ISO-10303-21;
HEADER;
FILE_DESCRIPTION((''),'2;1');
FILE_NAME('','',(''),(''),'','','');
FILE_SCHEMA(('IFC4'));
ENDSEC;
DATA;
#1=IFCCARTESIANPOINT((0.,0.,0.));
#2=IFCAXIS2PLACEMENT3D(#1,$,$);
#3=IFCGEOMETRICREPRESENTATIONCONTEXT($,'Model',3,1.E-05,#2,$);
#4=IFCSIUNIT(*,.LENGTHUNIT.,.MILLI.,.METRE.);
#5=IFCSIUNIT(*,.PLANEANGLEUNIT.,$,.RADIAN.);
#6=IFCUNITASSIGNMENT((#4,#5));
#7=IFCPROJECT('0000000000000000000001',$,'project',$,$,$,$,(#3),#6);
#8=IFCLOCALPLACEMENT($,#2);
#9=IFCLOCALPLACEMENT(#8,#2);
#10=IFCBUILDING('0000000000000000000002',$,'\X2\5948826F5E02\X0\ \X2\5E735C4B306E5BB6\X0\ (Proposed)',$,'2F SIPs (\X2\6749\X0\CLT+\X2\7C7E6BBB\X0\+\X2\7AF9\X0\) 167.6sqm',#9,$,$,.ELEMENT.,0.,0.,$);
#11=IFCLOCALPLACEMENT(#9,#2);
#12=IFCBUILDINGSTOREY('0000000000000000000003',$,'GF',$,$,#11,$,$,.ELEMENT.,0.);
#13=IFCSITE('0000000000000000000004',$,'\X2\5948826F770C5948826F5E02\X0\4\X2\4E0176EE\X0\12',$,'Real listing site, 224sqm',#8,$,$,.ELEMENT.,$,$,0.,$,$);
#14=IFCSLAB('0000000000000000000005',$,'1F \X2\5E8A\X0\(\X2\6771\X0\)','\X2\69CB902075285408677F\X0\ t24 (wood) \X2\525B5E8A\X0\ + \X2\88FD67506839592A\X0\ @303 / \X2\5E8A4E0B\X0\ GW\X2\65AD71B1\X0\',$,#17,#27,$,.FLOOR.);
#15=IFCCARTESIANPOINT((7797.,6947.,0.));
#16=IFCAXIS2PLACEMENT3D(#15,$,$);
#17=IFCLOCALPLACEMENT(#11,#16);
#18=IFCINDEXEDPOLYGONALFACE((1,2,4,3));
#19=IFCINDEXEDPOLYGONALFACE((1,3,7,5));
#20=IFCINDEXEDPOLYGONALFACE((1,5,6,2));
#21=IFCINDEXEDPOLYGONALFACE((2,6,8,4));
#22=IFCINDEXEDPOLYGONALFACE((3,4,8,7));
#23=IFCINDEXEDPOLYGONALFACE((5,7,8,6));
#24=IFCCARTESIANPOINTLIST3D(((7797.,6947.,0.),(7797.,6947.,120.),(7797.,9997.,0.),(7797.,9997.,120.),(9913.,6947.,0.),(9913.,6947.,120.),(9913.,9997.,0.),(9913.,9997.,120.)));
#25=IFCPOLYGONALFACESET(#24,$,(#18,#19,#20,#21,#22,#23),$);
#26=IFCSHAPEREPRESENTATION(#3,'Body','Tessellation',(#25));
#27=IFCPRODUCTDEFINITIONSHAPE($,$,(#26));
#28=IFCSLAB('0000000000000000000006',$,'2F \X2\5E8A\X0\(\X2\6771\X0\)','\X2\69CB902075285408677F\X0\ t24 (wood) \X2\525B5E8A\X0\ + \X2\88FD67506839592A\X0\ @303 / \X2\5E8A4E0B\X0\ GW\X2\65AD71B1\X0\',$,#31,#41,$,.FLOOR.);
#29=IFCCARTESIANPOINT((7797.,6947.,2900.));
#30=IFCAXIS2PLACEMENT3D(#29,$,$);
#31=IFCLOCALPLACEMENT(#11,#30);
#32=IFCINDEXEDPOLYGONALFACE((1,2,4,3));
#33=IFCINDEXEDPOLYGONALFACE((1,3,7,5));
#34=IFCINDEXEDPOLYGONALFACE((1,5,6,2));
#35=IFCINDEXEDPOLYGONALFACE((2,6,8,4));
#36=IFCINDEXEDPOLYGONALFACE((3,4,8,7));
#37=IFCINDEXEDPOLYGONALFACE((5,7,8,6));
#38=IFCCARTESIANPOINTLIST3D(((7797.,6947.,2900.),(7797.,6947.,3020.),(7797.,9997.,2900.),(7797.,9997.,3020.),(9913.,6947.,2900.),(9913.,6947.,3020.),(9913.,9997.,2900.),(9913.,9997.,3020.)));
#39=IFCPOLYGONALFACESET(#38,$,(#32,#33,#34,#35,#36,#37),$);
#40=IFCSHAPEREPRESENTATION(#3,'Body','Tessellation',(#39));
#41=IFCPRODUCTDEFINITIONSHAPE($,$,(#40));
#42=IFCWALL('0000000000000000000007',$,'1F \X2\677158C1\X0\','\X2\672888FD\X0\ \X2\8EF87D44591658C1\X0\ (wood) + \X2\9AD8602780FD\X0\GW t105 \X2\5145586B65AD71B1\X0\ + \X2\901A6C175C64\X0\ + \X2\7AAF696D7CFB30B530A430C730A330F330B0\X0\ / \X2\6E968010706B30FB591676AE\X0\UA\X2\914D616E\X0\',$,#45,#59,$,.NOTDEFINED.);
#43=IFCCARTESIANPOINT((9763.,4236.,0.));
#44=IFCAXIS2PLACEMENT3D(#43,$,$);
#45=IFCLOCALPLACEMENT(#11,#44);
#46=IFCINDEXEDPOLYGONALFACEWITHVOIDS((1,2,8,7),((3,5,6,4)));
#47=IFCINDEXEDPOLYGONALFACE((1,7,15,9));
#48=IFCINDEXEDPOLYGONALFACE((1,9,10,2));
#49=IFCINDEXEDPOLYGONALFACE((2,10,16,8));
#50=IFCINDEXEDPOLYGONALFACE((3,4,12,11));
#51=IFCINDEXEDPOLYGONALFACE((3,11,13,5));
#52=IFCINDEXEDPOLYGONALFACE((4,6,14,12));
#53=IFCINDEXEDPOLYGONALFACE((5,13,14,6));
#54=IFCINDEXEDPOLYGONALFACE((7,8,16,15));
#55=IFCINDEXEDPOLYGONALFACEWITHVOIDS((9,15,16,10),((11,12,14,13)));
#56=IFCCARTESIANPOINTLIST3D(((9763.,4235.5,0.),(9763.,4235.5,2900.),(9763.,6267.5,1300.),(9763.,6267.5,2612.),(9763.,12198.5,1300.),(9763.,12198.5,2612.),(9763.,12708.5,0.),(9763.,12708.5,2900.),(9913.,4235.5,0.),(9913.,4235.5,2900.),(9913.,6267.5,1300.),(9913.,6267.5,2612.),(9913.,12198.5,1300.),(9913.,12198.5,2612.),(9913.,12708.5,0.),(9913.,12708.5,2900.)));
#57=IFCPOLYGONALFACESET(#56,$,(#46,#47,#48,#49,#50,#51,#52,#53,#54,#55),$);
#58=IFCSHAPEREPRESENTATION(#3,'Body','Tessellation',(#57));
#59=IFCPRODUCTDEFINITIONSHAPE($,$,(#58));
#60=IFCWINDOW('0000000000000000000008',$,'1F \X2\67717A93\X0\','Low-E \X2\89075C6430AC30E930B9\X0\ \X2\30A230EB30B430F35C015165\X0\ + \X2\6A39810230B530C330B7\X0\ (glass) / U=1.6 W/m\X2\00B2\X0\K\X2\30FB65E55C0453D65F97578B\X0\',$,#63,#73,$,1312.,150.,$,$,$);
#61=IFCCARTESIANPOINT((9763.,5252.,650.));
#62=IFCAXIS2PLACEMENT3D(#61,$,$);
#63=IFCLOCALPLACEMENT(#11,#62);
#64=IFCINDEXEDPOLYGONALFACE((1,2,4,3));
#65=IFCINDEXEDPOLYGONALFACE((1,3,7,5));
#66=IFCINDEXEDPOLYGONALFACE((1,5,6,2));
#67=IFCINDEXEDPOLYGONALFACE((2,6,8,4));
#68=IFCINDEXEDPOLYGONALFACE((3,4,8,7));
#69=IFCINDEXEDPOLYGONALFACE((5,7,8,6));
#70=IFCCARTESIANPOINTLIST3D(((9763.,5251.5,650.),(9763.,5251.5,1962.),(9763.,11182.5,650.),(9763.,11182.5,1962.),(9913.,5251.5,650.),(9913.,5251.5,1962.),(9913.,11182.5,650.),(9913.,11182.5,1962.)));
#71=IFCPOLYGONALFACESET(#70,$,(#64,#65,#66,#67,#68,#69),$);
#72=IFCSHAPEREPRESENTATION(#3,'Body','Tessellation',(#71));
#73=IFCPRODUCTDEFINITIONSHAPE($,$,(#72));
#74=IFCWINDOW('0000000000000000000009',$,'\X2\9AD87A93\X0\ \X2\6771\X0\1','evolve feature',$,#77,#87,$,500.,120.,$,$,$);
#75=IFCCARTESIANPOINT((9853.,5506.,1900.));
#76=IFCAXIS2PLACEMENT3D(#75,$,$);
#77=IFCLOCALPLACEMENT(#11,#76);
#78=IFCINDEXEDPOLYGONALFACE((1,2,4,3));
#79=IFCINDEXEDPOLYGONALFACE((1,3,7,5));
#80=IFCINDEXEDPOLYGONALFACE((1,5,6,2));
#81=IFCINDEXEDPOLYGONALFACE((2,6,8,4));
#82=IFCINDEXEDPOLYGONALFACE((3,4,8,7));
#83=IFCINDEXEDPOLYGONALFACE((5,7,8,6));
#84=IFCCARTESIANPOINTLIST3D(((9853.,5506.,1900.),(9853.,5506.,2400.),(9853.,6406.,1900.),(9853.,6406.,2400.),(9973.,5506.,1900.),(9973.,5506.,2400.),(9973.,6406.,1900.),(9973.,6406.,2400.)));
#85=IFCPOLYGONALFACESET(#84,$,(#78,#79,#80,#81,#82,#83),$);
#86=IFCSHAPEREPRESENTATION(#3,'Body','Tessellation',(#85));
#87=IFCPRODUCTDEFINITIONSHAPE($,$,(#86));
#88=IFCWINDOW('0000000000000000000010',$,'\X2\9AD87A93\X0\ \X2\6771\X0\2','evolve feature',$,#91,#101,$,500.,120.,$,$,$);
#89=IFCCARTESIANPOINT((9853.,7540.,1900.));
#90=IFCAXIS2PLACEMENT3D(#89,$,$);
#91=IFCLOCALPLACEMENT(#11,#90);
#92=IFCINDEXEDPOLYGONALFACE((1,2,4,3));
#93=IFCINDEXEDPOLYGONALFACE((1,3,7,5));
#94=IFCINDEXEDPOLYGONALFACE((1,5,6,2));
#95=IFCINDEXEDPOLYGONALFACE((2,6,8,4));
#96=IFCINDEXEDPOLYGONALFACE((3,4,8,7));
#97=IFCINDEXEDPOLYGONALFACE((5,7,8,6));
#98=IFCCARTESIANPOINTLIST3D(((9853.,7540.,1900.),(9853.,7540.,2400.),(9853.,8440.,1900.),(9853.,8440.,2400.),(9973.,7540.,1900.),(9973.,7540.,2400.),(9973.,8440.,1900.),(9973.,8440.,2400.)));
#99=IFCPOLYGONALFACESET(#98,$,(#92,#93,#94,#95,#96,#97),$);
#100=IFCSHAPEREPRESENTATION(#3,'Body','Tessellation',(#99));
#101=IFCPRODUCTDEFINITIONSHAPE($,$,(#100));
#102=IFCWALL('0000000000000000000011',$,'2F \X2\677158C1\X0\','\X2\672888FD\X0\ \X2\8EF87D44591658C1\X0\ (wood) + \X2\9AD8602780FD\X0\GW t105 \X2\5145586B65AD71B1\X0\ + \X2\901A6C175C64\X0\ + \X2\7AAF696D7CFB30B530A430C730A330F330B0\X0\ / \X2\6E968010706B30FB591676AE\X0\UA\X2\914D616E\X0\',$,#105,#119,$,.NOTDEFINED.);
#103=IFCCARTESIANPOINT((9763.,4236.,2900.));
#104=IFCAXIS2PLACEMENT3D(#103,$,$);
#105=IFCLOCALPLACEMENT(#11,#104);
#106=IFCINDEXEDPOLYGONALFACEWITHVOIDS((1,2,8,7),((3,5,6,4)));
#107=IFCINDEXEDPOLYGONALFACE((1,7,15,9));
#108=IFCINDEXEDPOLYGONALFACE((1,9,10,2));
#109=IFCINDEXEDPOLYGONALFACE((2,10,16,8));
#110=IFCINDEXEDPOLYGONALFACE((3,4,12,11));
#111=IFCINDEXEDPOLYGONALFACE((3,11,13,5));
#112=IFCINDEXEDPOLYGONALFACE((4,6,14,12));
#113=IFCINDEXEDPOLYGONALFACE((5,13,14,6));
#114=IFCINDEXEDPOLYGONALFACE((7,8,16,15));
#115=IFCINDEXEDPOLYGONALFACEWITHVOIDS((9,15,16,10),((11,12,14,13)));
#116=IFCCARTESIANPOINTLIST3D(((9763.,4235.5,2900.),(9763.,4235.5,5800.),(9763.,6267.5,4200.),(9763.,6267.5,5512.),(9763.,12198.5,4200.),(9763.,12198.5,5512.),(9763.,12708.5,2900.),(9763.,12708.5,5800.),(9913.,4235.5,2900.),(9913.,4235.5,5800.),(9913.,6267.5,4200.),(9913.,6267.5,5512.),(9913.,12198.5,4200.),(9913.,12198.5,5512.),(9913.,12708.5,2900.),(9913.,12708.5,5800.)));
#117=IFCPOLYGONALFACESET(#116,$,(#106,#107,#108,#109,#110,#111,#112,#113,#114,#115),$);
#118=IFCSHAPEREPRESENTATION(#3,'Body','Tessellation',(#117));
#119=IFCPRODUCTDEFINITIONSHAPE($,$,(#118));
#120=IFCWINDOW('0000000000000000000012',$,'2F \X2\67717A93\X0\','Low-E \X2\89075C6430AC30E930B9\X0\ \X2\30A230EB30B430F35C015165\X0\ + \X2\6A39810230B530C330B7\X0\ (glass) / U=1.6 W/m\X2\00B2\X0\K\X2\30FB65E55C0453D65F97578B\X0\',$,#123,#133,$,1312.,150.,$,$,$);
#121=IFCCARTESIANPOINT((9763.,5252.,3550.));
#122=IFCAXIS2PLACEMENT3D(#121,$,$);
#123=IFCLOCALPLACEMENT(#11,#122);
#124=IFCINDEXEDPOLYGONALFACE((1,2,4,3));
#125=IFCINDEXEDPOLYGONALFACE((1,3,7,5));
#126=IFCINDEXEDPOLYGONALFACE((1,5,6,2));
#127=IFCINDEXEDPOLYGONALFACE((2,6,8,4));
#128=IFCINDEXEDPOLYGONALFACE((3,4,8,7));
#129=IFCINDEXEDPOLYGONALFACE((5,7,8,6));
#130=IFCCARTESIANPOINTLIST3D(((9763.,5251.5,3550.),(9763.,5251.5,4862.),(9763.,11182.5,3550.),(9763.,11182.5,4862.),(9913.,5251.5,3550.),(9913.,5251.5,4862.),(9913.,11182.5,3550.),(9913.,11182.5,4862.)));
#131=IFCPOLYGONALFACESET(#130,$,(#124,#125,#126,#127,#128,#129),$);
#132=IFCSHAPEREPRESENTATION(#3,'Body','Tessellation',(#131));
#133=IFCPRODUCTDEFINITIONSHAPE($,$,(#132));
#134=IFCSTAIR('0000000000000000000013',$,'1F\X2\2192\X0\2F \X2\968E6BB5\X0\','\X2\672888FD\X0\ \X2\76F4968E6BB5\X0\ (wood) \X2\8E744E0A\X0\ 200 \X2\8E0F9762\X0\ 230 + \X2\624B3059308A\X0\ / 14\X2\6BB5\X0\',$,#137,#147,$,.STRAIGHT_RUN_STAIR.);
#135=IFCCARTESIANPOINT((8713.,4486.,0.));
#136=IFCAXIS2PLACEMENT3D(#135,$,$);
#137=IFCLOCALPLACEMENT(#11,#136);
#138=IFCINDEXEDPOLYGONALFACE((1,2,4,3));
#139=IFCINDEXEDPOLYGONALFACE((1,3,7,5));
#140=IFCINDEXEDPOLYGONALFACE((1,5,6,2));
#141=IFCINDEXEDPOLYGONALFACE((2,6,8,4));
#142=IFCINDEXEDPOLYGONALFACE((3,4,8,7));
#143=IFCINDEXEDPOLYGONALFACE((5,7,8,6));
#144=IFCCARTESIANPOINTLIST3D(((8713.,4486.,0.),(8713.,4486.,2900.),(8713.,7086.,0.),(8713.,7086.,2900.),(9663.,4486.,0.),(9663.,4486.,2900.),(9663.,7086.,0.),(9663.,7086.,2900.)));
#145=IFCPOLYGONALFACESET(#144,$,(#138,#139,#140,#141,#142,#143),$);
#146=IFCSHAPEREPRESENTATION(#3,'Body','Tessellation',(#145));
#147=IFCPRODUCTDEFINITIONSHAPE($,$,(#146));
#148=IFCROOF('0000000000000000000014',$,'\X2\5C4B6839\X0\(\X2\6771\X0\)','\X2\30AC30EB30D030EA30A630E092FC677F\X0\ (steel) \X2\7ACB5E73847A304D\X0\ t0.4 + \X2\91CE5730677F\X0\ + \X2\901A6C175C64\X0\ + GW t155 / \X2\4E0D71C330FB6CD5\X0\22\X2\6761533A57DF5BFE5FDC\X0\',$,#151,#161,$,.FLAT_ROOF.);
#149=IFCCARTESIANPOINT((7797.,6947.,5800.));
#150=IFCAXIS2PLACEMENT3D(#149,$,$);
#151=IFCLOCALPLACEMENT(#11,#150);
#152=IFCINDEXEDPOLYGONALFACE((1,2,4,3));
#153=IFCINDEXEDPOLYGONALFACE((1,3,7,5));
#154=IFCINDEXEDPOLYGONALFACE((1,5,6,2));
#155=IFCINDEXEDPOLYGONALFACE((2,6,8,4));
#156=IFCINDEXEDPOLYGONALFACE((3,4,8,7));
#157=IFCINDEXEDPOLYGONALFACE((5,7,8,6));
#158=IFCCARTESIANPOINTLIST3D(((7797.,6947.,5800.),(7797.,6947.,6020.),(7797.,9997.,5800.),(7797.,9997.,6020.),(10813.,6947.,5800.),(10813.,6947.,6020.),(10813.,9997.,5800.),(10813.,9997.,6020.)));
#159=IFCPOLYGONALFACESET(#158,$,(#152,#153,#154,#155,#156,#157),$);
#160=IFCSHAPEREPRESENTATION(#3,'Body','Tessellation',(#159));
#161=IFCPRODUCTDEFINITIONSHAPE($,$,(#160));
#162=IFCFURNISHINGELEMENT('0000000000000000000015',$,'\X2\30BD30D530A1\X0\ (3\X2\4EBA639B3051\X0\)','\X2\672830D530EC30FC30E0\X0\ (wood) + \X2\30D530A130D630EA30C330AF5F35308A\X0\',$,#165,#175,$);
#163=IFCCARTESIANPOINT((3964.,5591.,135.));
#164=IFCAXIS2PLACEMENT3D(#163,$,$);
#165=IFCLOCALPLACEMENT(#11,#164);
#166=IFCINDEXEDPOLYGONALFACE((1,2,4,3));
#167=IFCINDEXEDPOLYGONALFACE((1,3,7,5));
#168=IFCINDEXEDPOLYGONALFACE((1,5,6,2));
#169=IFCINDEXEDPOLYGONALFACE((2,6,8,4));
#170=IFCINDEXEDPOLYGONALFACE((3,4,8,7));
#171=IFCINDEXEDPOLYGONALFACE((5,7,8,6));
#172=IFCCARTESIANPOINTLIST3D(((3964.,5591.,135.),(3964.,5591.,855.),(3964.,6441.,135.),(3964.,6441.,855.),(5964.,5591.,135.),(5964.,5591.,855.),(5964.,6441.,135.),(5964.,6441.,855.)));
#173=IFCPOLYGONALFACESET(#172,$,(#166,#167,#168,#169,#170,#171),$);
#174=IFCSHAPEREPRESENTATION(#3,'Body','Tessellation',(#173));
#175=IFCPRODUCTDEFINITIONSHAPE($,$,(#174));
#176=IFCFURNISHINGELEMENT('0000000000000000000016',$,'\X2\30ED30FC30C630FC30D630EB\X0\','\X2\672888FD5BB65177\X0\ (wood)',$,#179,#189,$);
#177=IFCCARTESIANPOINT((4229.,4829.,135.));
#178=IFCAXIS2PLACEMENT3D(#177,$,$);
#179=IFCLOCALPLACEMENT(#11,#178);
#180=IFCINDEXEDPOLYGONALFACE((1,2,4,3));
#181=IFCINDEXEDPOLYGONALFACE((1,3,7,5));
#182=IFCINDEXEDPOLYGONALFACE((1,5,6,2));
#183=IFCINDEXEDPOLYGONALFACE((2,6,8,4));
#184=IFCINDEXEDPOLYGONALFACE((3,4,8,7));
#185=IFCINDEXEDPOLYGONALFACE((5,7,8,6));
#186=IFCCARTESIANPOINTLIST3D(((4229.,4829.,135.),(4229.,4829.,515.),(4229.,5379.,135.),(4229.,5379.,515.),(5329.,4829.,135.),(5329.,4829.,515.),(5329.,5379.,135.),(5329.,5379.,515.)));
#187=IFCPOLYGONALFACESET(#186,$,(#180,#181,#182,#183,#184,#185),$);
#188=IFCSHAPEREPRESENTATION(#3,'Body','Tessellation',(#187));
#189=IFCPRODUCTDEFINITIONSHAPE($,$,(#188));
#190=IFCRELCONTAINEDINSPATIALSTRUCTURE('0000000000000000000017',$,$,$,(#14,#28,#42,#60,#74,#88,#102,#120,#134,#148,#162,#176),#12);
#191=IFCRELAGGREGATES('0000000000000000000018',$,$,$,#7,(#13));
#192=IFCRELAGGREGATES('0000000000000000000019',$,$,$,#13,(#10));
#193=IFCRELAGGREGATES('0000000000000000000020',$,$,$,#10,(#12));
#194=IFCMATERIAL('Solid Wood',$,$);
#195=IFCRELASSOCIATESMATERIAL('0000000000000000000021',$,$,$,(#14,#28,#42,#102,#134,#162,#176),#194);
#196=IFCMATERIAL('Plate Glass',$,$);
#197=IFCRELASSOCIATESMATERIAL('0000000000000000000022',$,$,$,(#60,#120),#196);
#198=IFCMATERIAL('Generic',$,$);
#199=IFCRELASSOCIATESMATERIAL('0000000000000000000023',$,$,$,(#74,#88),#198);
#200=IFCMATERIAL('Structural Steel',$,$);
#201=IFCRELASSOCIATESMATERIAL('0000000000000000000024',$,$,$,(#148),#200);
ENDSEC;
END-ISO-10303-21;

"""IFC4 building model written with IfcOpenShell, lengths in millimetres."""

from ifc_helpers import new_model, si_unit, frame, frame_2d, origin, place, context, project, spatial, rectangle, extrude, material, element, fill, save


model = new_model("IFC4")

# Units and contexts
model_context = context("Model", 3, precision=1e-05, world=origin())
ifc_project = project(units=[si_unit("LENGTHUNIT", "METRE", prefix="MILLI"), si_unit("PLANEANGLEUNIT", "RADIAN")], contexts=[model_context])

# Site, building, storey
site_placement = place(None, origin())
site = spatial("IfcSite", under=ifc_project, at=site_placement, Name="奈良県奈良市4丁目12", ObjectType="Real listing site, 224sqm", CompositionType="ELEMENT", RefElevation=0.0)
building_placement = place(site_placement, origin())
building = spatial("IfcBuilding", under=site, at=building_placement, Name="奈良市 平屋の家 (Proposed)", ObjectType="2F SIPs (杉CLT+籾殻+竹) 167.6sqm", CompositionType="ELEMENT", ElevationOfRefHeight=0.0, ElevationOfTerrain=0.0)
storey_placement = place(building_placement, origin())
storey = spatial("IfcBuildingStorey", under=building, at=storey_placement, Name="GF", CompositionType="ELEMENT", Elevation=0.0)

# Slabs
ifc_material_1 = material(Name="Solid Wood")
slab_1_placement = place(storey_placement, frame((7797.0, 6947.0, 0.0)))
element("IfcSlab", 1, at=slab_1_placement, inside=storey, material=ifc_material_1, Name="1F 床(東)", Description="構造用合板 t24 (wood) 剛床 + 製材根太 @303 / 床下 GW断熱", PredefinedType="FLOOR", context=model_context, shape_type="SweptSolid", body=[
    extrude(rectangle(XDim=2116.0, YDim=3050.0, at=frame_2d((1058.0, 1525.0))), frame((7797.0, 6947.0, 0.0)), (0.0, 0.0, 1.0), 120.0),
])
slab_2_placement = place(storey_placement, frame((7797.0, 6947.0, 2900.0)))
element("IfcSlab", 2, at=slab_2_placement, inside=storey, material=ifc_material_1, Name="2F 床(東)", Description="構造用合板 t24 (wood) 剛床 + 製材根太 @303 / 床下 GW断熱", PredefinedType="FLOOR", context=model_context, shape_type="SweptSolid", body=[
    extrude(rectangle(XDim=2116.0, YDim=3050.0, at=frame_2d((1058.0, 1525.0))), frame((7797.0, 6947.0, 2900.0)), (0.0, 0.0, 1.0), 120.0),
])

# Wall, openings, windows
wall_1_placement = place(storey_placement, frame((9763.0, 4236.0, 0.0)))
wall_1 = element("IfcWall", 3, at=wall_1_placement, inside=storey, material=ifc_material_1, Name="1F 東壁", Description="木製 軸組外壁 (wood) + 高性能GW t105 充填断熱 + 通気層 + 窯業系サイディング / 準耐火・外皮UA配慮", PredefinedType="NOTDEFINED", context=model_context, shape_type="SweptSolid", body=[
    extrude(rectangle(XDim=150.0, YDim=8473.0, at=frame_2d((75.0, 4236.0))), frame((9763.0, 4236.0, 0.0)), (0.0, 0.0, 1.0), 2900.0),
])
opening_1_placement = place(storey_placement, frame((9763.0, 5252.0, 650.0)))
opening_1 = element("IfcOpeningElement", 4, at=opening_1_placement, cuts=wall_1, PredefinedType="NOTDEFINED", context=model_context, shape_type="SweptSolid", body=[
    extrude(rectangle(XDim=150.0, YDim=5931.0, at=frame_2d((75.0, 2965.0))), frame((9763.0, 5252.0, 650.0)), (0.0, 0.0, 1.0), 1312.0),
])
opening_2_placement = place(storey_placement, frame((9853.0, 5506.0, 1900.0)))
opening_2 = element("IfcOpeningElement", 5, at=opening_2_placement, cuts=wall_1, PredefinedType="NOTDEFINED", context=model_context, shape_type="SweptSolid", body=[
    extrude(rectangle(XDim=120.0, YDim=900.0, at=frame_2d((60.0, 450.0))), frame((9853.0, 5506.0, 1900.0)), (0.0, 0.0, 1.0), 500.0),
])
opening_3_placement = place(storey_placement, frame((9853.0, 7540.0, 1900.0)))
opening_3 = element("IfcOpeningElement", 6, at=opening_3_placement, cuts=wall_1, PredefinedType="NOTDEFINED", context=model_context, shape_type="SweptSolid", body=[
    extrude(rectangle(XDim=120.0, YDim=900.0, at=frame_2d((60.0, 450.0))), frame((9853.0, 7540.0, 1900.0)), (0.0, 0.0, 1.0), 500.0),
])
ifc_material_2 = material(Name="Plate Glass")
window_1_placement = place(storey_placement, frame((9763.0, 5252.0, 650.0)))
window_1 = element("IfcWindow", 7, at=window_1_placement, inside=storey, material=ifc_material_2, Name="1F 東窓", Description="Low-E 複層ガラス アルゴン封入 + 樹脂サッシ (glass) / U=1.6 W/m²K・日射取得型", OverallHeight=1312.0, OverallWidth=150.0, context=model_context, shape_type="SweptSolid", body=[
    extrude(rectangle(XDim=150.0, YDim=5931.0, at=frame_2d((75.0, 2965.0))), frame((9763.0, 5252.0, 650.0)), (0.0, 0.0, 1.0), 1312.0),
])
fill(opening_1, window_1)
ifc_material_3 = material(Name="Generic")
window_2_placement = place(storey_placement, frame((9853.0, 5506.0, 1900.0)))
window_2 = element("IfcWindow", 8, at=window_2_placement, inside=storey, material=ifc_material_3, Name="高窓 東1", Description="evolve feature", OverallHeight=500.0, OverallWidth=120.0, context=model_context, shape_type="SweptSolid", body=[
    extrude(rectangle(XDim=120.0, YDim=900.0, at=frame_2d((60.0, 450.0))), frame((9853.0, 5506.0, 1900.0)), (0.0, 0.0, 1.0), 500.0),
])
fill(opening_2, window_2)
window_3_placement = place(storey_placement, frame((9853.0, 7540.0, 1900.0)))
window_3 = element("IfcWindow", 9, at=window_3_placement, inside=storey, material=ifc_material_3, Name="高窓 東2", Description="evolve feature", OverallHeight=500.0, OverallWidth=120.0, context=model_context, shape_type="SweptSolid", body=[
    extrude(rectangle(XDim=120.0, YDim=900.0, at=frame_2d((60.0, 450.0))), frame((9853.0, 7540.0, 1900.0)), (0.0, 0.0, 1.0), 500.0),
])
fill(opening_3, window_3)

# Wall, opening, window
wall_2_placement = place(storey_placement, frame((9763.0, 4236.0, 2900.0)))
wall_2 = element("IfcWall", 10, at=wall_2_placement, inside=storey, material=ifc_material_1, Name="2F 東壁", Description="木製 軸組外壁 (wood) + 高性能GW t105 充填断熱 + 通気層 + 窯業系サイディング / 準耐火・外皮UA配慮", PredefinedType="NOTDEFINED", context=model_context, shape_type="SweptSolid", body=[
    extrude(rectangle(XDim=150.0, YDim=8473.0, at=frame_2d((75.0, 4236.0))), frame((9763.0, 4236.0, 2900.0)), (0.0, 0.0, 1.0), 2900.0),
])
opening_4_placement = place(storey_placement, frame((9763.0, 5252.0, 3550.0)))
opening_4 = element("IfcOpeningElement", 11, at=opening_4_placement, cuts=wall_2, PredefinedType="NOTDEFINED", context=model_context, shape_type="SweptSolid", body=[
    extrude(rectangle(XDim=150.0, YDim=5931.0, at=frame_2d((75.0, 2965.0))), frame((9763.0, 5252.0, 3550.0)), (0.0, 0.0, 1.0), 1312.0),
])
window_4_placement = place(storey_placement, frame((9763.0, 5252.0, 3550.0)))
window_4 = element("IfcWindow", 12, at=window_4_placement, inside=storey, material=ifc_material_2, Name="2F 東窓", Description="Low-E 複層ガラス アルゴン封入 + 樹脂サッシ (glass) / U=1.6 W/m²K・日射取得型", OverallHeight=1312.0, OverallWidth=150.0, context=model_context, shape_type="SweptSolid", body=[
    extrude(rectangle(XDim=150.0, YDim=5931.0, at=frame_2d((75.0, 2965.0))), frame((9763.0, 5252.0, 3550.0)), (0.0, 0.0, 1.0), 1312.0),
])
fill(opening_4, window_4)

# Stair
stair_placement = place(storey_placement, frame((8713.0, 4486.0, 0.0)))
element("IfcStair", 13, at=stair_placement, inside=storey, material=ifc_material_1, Name="1F→2F 階段", Description="木製 直階段 (wood) 蹴上 200 踏面 230 + 手すり / 14段", PredefinedType="STRAIGHT_RUN_STAIR", context=model_context, shape_type="SweptSolid", body=[
    extrude(rectangle(XDim=950.0, YDim=2600.0, at=frame_2d((475.0, 1300.0))), frame((8713.0, 4486.0, 0.0)), (0.0, 0.0, 1.0), 2900.0),
])

# Roof
ifc_material_4 = material(Name="Structural Steel")
roof_placement = place(storey_placement, frame((7797.0, 6947.0, 5800.0)))
element("IfcRoof", 14, at=roof_placement, inside=storey, material=ifc_material_4, Name="屋根(東)", Description="ガルバリウム鋼板 (steel) 立平葺き t0.4 + 野地板 + 通気層 + GW t155 / 不燃・法22条区域対応", PredefinedType="FLAT_ROOF", context=model_context, shape_type="SweptSolid", body=[
    extrude(rectangle(XDim=3016.0, YDim=3050.0, at=frame_2d((1508.0, 1525.0))), frame((7797.0, 6947.0, 5800.0)), (0.0, 0.0, 1.0), 220.0),
])

# Furnishing elements
furnishing_1_placement = place(storey_placement, frame((3964.0, 5591.0, 135.0)))
element("IfcFurnishingElement", 15, at=furnishing_1_placement, inside=storey, material=ifc_material_1, Name="ソファ (3人掛け)", Description="木フレーム (wood) + ファブリック張り", context=model_context, shape_type="SweptSolid", body=[
    extrude(rectangle(XDim=2000.0, YDim=850.0, at=frame_2d((1000.0, 425.0))), frame((3964.0, 5591.0, 135.0)), (0.0, 0.0, 1.0), 720.0),
])
furnishing_2_placement = place(storey_placement, frame((4229.0, 4829.0, 135.0)))
element("IfcFurnishingElement", 16, at=furnishing_2_placement, inside=storey, material=ifc_material_1, Name="ローテーブル", Description="木製家具 (wood)", context=model_context, shape_type="SweptSolid", body=[
    extrude(rectangle(XDim=1100.0, YDim=550.0, at=frame_2d((550.0, 275.0))), frame((4229.0, 4829.0, 135.0)), (0.0, 0.0, 1.0), 380.0),
])

save(model, "model.ifc")
